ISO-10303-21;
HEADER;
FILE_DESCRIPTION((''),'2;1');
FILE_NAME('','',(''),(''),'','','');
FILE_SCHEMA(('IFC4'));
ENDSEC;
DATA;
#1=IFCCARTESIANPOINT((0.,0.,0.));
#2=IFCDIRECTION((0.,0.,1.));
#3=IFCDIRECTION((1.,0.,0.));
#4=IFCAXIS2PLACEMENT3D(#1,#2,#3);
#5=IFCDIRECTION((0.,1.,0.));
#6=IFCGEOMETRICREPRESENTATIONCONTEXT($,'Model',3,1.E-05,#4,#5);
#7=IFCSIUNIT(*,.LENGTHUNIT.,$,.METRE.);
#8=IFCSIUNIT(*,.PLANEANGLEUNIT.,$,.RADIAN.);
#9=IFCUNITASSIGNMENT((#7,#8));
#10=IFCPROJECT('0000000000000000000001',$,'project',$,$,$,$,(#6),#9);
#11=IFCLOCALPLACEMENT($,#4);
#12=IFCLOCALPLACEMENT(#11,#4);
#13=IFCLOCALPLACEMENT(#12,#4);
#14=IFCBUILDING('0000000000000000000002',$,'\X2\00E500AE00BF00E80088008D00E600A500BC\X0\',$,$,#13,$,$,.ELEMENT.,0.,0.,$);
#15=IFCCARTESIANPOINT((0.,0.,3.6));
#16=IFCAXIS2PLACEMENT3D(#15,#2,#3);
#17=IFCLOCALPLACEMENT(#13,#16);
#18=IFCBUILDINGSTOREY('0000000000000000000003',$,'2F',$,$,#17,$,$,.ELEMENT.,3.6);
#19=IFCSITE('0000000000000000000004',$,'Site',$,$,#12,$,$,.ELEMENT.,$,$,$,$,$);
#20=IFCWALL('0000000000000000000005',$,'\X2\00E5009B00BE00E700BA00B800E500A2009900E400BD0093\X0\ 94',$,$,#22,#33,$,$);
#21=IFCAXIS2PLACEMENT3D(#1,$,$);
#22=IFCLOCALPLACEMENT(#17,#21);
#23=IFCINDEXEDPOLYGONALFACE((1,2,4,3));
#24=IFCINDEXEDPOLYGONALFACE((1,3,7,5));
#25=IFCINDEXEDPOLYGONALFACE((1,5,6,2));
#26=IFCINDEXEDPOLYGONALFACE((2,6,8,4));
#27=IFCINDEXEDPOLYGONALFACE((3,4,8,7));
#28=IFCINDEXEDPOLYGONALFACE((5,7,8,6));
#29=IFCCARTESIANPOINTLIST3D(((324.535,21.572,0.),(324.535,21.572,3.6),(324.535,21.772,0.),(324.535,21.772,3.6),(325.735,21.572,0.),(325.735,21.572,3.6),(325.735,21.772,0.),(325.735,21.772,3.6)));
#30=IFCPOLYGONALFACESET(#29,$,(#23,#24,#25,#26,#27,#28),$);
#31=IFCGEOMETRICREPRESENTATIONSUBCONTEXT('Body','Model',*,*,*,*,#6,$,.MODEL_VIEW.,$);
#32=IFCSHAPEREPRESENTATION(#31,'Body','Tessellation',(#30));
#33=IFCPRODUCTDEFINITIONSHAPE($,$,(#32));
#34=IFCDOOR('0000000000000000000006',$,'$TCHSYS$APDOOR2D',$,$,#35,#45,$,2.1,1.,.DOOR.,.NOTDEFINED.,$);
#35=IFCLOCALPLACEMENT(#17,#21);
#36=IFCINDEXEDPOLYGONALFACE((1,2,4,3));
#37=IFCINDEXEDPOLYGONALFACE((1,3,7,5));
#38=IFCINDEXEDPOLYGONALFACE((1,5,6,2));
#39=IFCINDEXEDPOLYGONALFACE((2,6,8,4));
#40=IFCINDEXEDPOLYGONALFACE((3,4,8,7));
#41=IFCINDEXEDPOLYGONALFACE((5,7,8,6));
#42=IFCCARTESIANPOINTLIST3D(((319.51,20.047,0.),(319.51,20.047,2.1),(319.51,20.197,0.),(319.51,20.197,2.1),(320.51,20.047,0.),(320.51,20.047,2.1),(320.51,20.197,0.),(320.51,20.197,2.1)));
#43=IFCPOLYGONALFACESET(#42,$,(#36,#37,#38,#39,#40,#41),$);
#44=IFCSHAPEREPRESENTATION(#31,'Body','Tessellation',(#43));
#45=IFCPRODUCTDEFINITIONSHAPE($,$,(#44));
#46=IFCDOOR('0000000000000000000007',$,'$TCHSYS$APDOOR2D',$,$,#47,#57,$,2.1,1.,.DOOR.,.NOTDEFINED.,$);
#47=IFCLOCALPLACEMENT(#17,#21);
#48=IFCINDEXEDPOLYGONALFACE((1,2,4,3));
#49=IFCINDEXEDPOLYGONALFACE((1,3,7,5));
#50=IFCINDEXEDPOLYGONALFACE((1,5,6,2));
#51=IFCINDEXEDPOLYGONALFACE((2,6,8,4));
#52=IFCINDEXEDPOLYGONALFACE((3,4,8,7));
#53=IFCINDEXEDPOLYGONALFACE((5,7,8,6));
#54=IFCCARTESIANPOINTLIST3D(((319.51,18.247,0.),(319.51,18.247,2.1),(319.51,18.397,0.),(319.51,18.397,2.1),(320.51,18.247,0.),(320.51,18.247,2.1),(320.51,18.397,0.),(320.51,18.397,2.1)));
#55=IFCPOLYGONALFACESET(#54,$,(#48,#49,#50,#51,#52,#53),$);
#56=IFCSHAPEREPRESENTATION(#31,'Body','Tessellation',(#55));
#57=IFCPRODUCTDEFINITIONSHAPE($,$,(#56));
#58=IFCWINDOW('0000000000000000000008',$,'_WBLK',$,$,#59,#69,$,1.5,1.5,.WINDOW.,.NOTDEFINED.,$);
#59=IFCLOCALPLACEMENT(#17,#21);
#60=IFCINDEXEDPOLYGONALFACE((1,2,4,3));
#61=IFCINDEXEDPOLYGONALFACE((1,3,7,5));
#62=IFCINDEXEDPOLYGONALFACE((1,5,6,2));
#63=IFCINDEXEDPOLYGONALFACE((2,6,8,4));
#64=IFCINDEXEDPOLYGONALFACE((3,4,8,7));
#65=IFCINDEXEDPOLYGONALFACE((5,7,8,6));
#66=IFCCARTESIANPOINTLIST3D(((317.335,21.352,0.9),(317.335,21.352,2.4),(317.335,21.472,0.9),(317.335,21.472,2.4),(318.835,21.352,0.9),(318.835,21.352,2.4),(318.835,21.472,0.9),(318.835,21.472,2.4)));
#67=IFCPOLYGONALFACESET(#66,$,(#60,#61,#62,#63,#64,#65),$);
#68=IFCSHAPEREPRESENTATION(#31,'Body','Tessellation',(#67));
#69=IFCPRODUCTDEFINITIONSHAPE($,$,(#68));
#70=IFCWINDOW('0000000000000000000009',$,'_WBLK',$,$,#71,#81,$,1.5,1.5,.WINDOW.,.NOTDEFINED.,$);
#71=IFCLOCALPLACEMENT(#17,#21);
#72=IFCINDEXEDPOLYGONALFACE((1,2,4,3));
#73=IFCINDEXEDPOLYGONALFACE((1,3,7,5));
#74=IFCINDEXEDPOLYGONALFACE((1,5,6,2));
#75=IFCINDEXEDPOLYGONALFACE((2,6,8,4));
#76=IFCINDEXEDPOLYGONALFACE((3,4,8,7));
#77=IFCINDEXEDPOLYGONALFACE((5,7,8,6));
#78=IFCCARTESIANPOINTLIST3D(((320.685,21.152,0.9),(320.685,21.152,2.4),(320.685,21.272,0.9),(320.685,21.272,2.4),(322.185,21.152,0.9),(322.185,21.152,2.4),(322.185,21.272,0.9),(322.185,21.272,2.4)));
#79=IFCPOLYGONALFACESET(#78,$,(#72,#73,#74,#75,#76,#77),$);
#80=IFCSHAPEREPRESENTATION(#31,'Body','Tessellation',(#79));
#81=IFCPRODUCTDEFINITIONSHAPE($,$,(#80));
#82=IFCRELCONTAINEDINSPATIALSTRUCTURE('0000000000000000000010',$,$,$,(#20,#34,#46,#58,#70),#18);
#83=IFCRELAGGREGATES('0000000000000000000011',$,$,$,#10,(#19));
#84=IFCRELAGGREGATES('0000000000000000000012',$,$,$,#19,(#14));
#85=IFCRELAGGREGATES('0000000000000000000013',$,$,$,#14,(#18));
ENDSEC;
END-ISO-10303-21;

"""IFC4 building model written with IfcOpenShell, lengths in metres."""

from ifc_helpers import new_model, si_unit, direction, frame, frame_2d, origin_with_axes, place, context, subcontext, project, spatial, rectangle, extrude, element, save


model = new_model("IFC4")

# Units and contexts
model_context = context("Model", 3, precision=1e-05, world=origin_with_axes(), true_north=direction((0.0, 1.0, 0.0)))
body_context = subcontext(model_context, "Body", "Model", "MODEL_VIEW")
ifc_project = project(units=[si_unit("LENGTHUNIT", "METRE"), si_unit("PLANEANGLEUNIT", "RADIAN")], contexts=[model_context])

# Site, building, storey
placement = place(None, origin_with_axes())
site_placement = place(placement, origin_with_axes())
site = spatial("IfcSite", under=ifc_project, at=site_placement, Name="Site", CompositionType="ELEMENT")
building_placement = place(site_placement, origin_with_axes())
building = spatial("IfcBuilding", under=site, at=building_placement, Name="å®¿è\u0088\u008dæ¥¼", CompositionType="ELEMENT", ElevationOfRefHeight=0.0, ElevationOfTerrain=0.0)
storey_placement = place(building_placement, frame((0.0, 0.0, 3.6), z_axis=(0.0, 0.0, 1.0), x_axis=(1.0, 0.0, 0.0)))
storey = spatial("IfcBuildingStorey", under=building, at=storey_placement, Name="2F", CompositionType="ELEMENT", Elevation=3.6)

# Wall
wall_1_placement = place(storey_placement, frame((325.135, 21.672, 0.0), z_axis=(0.0, 0.0, 1.0), x_axis=(1.0, 0.0, 0.0)))
element("IfcWall", 1, at=wall_1_placement, inside=storey, Name="å\u009b¾çº¸å¢\u0099ä½\u0093 94", context=body_context, shape_type="SweptSolid", body=[
    extrude(rectangle(XDim=1.2, YDim=0.2, at=frame_2d((0.0, 0.0), x_axis=(1.0, 0.0, 0.0))), frame((0.0, 0.0, 0.0), z_axis=(0.0, 0.0, 1.0)), (0.0, 0.0, 1.0), 3.6),
])

# Doors
for number, where, z_axis, x_axis, name in (
    (2, (320.01, 20.122, 0.0), (0.0, 0.0, 1.0), (1.0, 0.0, 0.0), "$TCHSYS$APDOOR2D"),
    (3, (320.01, 18.322, 0.0), (0.0, 0.0, 1.0), (1.0, 0.0, 0.0), "$TCHSYS$APDOOR2D"),
):
    element("IfcDoor", number, at=place(storey_placement, frame(where, z_axis=z_axis, x_axis=x_axis)), inside=storey, Name=name, OperationType="NOTDEFINED", OverallHeight=2.1, OverallWidth=1.0, PredefinedType="DOOR", context=body_context, shape_type="SweptSolid", body=[
        extrude(rectangle(XDim=1.0, YDim=0.15, at=frame_2d((0.0, 0.0), x_axis=(1.0, 0.0, 0.0))), frame((0.0, 0.0, 0.0), z_axis=(0.0, 0.0, 1.0)), (0.0, 0.0, 1.0), 2.1),
    ])

# Windows
for number, where, z_axis, x_axis, name in (
    (4, (318.085, 21.412, 0.9), (0.0, 0.0, 1.0), (1.0, 0.0, 0.0), "_WBLK"),
    (5, (321.435, 21.212, 0.9), (0.0, 0.0, 1.0), (1.0, 0.0, 0.0), "_WBLK"),
):
    element("IfcWindow", number, at=place(storey_placement, frame(where, z_axis=z_axis, x_axis=x_axis)), inside=storey, Name=name, OverallHeight=1.5, OverallWidth=1.5, PartitioningType="NOTDEFINED", PredefinedType="WINDOW", context=body_context, shape_type="SweptSolid", body=[
        extrude(rectangle(XDim=1.5, YDim=0.12, at=frame_2d((0.0, 0.0), x_axis=(1.0, 0.0, 0.0))), frame((0.0, 0.0, 0.0), z_axis=(0.0, 0.0, 1.0)), (0.0, 0.0, 1.0), 1.5),
    ])

save(model, "model.ifc")
